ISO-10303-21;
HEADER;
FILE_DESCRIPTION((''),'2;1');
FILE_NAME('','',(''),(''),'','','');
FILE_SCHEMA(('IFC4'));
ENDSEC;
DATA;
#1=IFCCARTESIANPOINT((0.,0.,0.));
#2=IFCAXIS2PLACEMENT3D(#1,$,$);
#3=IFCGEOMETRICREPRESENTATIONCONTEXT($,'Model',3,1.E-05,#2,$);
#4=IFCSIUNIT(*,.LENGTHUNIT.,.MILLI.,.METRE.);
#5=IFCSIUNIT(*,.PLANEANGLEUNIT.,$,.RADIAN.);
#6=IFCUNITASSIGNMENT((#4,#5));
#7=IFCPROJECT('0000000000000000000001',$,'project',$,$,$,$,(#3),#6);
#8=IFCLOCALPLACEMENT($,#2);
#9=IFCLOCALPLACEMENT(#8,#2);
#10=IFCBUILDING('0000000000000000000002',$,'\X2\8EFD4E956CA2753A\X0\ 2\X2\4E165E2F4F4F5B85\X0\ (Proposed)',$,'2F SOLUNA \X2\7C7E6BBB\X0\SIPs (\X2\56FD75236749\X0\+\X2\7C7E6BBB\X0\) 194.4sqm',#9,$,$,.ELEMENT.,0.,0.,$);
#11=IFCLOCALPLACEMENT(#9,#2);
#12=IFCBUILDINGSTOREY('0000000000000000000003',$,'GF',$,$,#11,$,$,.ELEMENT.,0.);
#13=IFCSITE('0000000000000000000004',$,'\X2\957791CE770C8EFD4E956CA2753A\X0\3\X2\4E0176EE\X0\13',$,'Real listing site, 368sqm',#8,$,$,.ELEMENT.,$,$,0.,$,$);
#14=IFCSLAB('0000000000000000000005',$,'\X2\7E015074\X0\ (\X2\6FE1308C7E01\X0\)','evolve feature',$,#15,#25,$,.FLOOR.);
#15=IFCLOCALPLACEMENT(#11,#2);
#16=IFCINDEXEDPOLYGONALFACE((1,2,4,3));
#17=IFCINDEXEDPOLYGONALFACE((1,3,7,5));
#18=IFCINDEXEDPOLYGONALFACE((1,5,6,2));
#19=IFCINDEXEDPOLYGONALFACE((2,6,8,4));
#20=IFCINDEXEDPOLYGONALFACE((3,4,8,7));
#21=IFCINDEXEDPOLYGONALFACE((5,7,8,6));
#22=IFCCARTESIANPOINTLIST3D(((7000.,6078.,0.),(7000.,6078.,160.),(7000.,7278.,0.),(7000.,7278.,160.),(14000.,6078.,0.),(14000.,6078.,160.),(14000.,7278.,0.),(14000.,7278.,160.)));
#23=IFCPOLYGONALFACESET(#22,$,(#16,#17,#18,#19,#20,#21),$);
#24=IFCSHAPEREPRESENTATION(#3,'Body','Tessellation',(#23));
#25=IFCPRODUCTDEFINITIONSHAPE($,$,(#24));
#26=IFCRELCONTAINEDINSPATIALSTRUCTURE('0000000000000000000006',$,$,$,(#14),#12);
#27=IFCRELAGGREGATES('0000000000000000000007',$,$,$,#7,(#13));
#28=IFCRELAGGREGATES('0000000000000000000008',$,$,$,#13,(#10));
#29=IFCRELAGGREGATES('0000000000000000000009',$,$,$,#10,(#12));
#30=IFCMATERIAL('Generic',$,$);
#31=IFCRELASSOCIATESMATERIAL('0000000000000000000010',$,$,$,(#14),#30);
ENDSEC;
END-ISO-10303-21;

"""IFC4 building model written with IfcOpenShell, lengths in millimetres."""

from ifc_helpers import new_model, si_unit, frame, frame_2d, origin, place, context, project, spatial, rectangle, extrude, material, element, save


model = new_model("IFC4")

# Units and contexts
model_context = context("Model", 3, precision=1e-05, world=origin())
ifc_project = project(units=[si_unit("LENGTHUNIT", "METRE", prefix="MILLI"), si_unit("PLANEANGLEUNIT", "RADIAN")], contexts=[model_context])

# Site, building, storey
site_placement = place(None, origin())
site = spatial("IfcSite", under=ifc_project, at=site_placement, Name="長野県軽井沢町3丁目13", ObjectType="Real listing site, 368sqm", CompositionType="ELEMENT", RefElevation=0.0)
building_placement = place(site_placement, origin())
building = spatial("IfcBuilding", under=site, at=building_placement, Name="軽井沢町 2世帯住宅 (Proposed)", ObjectType="2F SOLUNA 籾殻SIPs (国産杉+籾殻) 194.4sqm", CompositionType="ELEMENT", ElevationOfRefHeight=0.0, ElevationOfTerrain=0.0)
storey_placement = place(building_placement, origin())
storey = spatial("IfcBuildingStorey", under=building, at=storey_placement, Name="GF", CompositionType="ELEMENT", Elevation=0.0)

# Slab
ifc_material_1 = material(Name="Generic")
slab_1_placement = place(storey_placement, frame((3500.0, 3039.0, 0.0)))
element("IfcSlab", 1, at=slab_1_placement, inside=storey, material=ifc_material_1, Name="縁側 (濡れ縁)", Description="evolve feature", PredefinedType="FLOOR", context=model_context, shape_type="SweptSolid", body=[
    extrude(rectangle(XDim=7000.0, YDim=1200.0, at=frame_2d((3500.0, 600.0))), frame((3500.0, 3039.0, 0.0)), (0.0, 0.0, 1.0), 160.0),
])

save(model, "model.ifc")
